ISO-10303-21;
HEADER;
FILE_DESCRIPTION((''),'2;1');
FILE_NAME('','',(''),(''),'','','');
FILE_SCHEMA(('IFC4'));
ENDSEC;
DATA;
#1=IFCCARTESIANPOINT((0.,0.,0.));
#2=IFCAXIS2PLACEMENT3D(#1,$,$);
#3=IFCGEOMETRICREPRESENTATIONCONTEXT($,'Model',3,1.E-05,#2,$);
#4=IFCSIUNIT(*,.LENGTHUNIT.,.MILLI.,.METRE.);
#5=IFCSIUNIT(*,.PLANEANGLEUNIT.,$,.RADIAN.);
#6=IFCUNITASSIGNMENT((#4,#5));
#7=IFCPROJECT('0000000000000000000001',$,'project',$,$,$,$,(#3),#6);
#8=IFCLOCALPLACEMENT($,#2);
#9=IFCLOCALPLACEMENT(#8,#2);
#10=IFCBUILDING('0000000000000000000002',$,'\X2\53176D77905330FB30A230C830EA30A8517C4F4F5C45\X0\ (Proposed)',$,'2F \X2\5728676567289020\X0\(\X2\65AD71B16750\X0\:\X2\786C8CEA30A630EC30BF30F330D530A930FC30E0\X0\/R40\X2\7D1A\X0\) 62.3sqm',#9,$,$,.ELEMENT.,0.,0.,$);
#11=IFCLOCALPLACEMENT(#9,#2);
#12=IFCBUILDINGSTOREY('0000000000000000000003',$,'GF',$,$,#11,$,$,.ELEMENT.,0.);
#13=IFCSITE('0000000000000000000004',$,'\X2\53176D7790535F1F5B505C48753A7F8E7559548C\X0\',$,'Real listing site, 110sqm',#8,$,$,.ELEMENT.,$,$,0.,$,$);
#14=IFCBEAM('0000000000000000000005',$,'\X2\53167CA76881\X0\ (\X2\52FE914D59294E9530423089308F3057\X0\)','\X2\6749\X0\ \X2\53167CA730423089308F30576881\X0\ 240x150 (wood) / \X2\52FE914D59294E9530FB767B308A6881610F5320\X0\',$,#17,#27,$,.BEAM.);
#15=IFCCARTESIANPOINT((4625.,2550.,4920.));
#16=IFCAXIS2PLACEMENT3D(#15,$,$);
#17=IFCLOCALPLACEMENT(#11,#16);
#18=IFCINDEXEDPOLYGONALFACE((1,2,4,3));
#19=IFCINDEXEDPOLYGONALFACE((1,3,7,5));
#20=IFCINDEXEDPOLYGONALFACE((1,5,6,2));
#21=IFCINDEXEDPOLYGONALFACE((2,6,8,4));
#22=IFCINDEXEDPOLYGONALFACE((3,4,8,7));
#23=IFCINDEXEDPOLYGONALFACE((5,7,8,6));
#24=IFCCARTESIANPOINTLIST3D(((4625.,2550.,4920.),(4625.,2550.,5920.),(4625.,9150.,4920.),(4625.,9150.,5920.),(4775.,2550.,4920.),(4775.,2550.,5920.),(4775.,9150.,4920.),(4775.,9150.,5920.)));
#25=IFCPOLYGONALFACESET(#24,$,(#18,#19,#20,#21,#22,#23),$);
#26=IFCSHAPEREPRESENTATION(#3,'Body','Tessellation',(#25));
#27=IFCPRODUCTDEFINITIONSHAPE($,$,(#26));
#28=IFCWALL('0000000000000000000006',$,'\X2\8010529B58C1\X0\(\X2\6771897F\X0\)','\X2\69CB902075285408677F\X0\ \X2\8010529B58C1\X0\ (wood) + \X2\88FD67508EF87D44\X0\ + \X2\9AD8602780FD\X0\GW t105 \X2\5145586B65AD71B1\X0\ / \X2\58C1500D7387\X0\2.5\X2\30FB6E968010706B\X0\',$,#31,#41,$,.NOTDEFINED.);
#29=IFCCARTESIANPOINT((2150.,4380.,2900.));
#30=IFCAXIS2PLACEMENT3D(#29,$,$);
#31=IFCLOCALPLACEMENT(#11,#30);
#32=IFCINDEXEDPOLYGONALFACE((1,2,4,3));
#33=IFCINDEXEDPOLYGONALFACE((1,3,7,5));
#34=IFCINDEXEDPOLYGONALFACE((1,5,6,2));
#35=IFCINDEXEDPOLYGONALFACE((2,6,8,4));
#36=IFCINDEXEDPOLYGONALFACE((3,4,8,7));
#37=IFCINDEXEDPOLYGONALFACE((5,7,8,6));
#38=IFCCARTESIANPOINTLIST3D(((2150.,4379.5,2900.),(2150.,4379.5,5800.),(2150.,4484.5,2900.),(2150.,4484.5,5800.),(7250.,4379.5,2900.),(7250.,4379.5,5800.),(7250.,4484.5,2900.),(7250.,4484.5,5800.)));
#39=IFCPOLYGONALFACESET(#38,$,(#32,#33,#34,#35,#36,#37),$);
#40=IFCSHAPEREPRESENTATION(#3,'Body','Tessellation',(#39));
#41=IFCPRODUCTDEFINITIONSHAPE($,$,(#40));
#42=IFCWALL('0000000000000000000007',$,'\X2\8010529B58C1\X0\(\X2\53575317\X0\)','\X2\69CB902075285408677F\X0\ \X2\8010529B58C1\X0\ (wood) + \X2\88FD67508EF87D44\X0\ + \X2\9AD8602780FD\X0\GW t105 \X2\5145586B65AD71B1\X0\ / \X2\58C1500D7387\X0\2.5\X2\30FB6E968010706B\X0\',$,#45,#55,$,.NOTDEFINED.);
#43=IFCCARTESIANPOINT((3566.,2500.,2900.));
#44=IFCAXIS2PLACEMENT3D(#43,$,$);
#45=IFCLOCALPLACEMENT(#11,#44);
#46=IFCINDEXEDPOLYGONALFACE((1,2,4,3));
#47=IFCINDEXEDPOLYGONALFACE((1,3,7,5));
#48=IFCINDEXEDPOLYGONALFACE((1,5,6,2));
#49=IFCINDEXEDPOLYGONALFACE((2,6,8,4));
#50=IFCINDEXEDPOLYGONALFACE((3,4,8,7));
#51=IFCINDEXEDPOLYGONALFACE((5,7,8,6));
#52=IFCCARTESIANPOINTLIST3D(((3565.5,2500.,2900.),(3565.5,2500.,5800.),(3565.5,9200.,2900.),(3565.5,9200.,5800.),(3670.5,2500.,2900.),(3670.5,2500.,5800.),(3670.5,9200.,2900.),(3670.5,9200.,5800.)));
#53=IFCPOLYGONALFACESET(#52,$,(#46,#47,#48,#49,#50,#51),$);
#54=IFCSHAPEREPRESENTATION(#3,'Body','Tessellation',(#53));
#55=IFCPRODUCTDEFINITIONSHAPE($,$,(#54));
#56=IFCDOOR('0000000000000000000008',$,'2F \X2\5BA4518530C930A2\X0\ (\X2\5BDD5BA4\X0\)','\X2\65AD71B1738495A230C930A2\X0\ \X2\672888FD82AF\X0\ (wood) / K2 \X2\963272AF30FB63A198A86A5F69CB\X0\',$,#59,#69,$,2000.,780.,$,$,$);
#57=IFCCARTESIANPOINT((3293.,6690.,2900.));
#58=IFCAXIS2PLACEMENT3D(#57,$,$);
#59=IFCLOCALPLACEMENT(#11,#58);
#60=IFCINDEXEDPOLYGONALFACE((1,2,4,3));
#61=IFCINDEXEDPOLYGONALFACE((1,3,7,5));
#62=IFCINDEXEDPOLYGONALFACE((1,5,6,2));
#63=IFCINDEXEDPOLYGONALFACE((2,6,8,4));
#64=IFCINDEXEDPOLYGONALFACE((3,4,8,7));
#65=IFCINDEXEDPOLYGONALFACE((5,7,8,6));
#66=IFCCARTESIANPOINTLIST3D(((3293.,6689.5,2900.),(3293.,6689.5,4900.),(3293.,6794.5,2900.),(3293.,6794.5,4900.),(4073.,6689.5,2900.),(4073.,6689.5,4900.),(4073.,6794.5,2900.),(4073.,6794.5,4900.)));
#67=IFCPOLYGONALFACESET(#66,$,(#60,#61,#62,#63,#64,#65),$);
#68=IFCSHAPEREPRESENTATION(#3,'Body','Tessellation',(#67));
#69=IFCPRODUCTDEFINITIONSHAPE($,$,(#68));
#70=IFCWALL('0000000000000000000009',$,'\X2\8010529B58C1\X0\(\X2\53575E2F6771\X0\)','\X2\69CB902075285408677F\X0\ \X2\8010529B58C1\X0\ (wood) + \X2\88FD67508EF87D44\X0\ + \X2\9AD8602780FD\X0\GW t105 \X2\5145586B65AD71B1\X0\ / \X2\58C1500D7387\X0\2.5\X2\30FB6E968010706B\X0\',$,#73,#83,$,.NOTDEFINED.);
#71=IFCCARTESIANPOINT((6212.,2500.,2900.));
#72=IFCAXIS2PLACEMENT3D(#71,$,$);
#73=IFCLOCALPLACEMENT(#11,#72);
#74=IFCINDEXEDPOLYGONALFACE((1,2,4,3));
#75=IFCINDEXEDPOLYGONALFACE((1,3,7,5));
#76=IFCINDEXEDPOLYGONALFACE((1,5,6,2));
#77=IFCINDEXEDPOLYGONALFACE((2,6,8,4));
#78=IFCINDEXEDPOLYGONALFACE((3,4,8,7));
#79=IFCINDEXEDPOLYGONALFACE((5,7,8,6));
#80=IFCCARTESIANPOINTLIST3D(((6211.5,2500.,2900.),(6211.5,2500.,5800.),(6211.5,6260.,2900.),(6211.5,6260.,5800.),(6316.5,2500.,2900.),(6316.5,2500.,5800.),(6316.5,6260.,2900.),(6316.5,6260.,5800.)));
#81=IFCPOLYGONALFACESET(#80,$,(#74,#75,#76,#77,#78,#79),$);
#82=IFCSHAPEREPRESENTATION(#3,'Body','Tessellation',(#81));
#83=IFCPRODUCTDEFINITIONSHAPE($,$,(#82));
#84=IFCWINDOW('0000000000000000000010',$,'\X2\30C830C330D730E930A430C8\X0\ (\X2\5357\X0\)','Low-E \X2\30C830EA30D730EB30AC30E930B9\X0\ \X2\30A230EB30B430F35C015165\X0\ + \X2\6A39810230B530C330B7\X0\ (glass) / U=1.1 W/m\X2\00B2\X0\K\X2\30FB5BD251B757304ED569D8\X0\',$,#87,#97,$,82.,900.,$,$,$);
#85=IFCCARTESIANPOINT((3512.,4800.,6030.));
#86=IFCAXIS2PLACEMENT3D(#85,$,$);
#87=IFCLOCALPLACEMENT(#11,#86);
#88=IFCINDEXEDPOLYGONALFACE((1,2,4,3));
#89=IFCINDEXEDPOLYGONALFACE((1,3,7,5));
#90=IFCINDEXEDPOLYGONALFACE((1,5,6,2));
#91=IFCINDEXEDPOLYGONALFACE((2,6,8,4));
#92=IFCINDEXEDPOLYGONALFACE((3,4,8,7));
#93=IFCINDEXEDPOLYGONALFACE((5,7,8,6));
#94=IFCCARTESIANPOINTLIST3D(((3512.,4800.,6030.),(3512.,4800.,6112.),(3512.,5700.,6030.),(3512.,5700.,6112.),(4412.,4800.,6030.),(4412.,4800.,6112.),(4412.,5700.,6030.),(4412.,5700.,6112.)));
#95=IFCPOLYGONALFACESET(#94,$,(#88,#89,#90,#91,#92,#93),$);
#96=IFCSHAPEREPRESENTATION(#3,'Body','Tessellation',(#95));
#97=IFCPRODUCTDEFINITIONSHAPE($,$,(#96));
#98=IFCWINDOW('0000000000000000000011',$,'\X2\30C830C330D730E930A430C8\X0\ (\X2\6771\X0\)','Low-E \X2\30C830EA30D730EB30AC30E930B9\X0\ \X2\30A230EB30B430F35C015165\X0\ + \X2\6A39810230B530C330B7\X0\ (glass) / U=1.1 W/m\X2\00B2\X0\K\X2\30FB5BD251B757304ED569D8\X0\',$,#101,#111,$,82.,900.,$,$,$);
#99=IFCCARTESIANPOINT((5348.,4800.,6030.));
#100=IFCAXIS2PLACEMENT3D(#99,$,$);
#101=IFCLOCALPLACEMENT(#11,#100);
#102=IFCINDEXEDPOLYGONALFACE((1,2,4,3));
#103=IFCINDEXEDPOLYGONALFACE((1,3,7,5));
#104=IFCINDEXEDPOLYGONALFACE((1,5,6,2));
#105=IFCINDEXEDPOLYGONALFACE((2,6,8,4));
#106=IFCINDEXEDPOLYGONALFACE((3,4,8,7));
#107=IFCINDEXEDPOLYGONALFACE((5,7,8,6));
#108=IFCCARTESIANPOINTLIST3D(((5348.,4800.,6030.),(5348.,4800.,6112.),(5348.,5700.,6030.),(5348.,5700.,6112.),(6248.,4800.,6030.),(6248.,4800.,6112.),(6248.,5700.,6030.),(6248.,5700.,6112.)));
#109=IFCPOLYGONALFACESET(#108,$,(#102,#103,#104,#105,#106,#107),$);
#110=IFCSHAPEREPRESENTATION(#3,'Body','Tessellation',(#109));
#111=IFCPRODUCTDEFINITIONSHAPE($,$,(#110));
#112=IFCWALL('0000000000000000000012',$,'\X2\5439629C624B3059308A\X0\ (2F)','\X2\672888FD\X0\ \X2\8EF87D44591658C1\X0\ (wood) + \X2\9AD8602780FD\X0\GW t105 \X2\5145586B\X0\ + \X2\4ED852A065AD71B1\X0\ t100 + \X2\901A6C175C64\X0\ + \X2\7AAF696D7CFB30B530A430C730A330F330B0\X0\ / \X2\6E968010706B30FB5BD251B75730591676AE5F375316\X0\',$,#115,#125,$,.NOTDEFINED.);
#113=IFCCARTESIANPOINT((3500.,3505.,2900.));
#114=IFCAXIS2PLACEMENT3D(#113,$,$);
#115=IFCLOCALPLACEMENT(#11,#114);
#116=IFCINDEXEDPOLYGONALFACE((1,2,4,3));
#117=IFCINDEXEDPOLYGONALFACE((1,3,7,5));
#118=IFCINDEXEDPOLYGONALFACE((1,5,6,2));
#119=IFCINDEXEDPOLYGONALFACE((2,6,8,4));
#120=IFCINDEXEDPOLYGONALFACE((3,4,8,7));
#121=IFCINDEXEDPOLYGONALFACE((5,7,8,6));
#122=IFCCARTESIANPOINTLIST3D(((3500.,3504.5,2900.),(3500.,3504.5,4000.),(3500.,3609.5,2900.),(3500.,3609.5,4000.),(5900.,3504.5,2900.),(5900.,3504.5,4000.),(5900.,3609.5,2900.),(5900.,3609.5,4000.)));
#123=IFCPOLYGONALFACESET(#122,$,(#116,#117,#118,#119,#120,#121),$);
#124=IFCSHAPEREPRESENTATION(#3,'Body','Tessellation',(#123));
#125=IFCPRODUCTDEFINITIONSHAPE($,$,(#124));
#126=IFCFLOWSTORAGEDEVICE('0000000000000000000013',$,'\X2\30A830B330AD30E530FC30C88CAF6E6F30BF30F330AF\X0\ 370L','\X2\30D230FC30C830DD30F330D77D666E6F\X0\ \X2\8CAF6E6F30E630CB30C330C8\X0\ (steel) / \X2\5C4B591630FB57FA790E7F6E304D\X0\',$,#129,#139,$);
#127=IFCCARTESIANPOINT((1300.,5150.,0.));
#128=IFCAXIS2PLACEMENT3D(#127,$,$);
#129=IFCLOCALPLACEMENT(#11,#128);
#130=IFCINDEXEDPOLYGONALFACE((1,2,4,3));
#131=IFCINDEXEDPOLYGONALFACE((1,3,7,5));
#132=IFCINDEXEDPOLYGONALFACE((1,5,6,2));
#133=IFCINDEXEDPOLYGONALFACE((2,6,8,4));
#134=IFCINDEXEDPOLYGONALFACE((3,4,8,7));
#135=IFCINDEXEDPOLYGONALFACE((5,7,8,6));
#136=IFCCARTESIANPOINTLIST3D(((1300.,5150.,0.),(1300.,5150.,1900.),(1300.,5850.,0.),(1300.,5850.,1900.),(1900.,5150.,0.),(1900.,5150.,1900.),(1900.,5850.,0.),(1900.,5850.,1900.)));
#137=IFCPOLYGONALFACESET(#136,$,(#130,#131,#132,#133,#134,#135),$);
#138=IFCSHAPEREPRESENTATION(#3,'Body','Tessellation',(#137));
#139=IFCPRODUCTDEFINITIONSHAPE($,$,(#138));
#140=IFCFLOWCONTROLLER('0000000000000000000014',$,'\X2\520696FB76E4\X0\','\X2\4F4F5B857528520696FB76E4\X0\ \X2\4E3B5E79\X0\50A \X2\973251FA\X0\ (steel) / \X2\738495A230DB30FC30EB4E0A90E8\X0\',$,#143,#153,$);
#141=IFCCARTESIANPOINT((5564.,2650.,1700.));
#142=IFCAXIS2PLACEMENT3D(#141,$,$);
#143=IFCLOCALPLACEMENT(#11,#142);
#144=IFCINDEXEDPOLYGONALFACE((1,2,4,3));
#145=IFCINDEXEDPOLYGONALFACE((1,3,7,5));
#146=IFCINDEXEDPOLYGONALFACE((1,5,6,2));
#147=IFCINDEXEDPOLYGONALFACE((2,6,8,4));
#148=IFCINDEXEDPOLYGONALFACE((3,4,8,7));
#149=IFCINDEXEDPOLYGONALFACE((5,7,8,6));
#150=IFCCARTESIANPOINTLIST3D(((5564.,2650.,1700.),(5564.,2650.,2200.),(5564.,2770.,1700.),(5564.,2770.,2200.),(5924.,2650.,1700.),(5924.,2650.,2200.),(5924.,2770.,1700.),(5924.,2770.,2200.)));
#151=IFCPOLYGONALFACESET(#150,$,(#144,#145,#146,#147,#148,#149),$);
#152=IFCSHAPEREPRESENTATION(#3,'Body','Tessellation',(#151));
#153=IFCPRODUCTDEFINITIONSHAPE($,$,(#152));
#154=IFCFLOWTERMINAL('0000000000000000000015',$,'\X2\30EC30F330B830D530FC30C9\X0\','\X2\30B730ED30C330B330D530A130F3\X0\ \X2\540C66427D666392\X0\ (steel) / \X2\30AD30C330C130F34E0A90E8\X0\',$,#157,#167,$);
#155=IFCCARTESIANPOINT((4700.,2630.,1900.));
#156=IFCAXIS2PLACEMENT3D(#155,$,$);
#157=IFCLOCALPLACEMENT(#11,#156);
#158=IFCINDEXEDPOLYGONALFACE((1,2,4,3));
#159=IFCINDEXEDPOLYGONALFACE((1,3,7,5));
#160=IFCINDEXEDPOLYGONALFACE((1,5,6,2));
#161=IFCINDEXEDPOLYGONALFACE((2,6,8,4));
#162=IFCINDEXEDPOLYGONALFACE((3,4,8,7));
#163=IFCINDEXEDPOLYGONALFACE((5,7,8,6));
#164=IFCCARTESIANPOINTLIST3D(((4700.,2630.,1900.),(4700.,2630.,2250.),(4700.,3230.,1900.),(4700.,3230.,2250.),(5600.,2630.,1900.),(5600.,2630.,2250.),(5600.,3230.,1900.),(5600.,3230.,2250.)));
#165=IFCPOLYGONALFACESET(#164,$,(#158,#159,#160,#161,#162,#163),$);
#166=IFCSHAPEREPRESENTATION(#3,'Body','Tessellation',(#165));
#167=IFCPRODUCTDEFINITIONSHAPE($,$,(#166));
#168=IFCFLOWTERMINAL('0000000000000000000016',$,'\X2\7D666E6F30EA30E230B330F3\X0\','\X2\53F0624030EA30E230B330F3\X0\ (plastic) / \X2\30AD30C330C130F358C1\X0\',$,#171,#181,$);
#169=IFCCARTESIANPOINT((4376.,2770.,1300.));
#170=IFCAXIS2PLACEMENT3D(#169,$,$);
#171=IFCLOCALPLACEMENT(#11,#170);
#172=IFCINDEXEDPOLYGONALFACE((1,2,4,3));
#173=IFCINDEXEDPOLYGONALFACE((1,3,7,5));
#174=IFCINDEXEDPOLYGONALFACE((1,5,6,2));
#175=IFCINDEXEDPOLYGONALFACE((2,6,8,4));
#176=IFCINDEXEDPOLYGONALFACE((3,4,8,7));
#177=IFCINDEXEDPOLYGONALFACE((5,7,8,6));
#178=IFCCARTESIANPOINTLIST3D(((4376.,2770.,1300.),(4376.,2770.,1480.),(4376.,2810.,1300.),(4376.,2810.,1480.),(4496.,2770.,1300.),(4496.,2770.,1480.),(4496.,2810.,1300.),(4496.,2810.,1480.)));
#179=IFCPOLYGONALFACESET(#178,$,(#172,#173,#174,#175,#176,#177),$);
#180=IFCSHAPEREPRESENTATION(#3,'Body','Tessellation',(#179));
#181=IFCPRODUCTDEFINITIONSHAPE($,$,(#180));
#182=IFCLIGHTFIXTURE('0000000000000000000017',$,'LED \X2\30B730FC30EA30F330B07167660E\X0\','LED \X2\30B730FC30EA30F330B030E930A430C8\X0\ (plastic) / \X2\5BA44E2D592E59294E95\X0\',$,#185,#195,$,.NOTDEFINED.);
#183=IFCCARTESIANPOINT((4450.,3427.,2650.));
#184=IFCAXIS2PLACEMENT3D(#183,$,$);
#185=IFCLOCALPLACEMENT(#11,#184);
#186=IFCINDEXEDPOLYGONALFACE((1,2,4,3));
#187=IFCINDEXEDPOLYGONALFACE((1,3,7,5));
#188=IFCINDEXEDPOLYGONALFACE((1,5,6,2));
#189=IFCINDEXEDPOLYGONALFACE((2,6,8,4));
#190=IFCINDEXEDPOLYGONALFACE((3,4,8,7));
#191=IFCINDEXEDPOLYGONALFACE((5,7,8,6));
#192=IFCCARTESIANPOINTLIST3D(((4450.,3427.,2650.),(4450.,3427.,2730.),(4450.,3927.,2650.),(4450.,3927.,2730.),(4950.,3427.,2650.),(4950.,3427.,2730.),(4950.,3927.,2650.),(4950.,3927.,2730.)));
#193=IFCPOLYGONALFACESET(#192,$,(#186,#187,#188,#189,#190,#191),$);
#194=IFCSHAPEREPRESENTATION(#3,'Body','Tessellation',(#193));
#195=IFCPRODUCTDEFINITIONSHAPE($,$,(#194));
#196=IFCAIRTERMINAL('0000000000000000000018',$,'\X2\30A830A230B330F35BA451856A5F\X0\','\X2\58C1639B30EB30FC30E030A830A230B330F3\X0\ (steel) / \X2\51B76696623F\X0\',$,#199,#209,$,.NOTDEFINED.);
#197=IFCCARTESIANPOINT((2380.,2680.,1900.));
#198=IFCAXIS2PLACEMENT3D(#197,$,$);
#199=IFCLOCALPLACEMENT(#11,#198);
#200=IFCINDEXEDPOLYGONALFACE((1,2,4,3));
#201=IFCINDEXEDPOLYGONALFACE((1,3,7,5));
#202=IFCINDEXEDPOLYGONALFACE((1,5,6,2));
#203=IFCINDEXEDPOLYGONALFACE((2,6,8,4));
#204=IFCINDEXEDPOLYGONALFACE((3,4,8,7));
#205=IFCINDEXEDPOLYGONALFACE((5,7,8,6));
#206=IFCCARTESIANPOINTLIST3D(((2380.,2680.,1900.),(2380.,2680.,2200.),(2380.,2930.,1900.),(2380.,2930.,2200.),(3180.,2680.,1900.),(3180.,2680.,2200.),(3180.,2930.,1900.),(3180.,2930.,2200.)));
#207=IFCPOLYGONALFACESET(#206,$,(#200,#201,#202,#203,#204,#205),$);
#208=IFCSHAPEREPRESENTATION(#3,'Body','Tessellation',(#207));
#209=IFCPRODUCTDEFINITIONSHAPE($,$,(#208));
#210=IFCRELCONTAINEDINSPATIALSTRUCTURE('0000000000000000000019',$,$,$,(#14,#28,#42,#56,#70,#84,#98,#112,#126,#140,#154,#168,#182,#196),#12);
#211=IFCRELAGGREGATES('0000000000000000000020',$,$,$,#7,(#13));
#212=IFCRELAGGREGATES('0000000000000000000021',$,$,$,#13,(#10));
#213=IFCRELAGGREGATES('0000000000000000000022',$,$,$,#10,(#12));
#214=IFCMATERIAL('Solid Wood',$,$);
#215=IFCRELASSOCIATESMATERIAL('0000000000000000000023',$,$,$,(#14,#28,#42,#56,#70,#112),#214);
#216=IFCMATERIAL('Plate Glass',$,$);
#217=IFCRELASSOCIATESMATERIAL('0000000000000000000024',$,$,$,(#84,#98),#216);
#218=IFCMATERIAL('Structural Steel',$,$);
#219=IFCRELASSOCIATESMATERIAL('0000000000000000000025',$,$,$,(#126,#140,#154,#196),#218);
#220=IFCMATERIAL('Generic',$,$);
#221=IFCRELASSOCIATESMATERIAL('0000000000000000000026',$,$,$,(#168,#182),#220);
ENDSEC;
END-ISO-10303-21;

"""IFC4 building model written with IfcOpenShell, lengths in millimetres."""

from ifc_helpers import new_model, si_unit, frame, frame_2d, origin, place, context, project, spatial, rectangle, extrude, material, element, fill, save


model = new_model("IFC4")

# Units and contexts
model_context = context("Model", 3, precision=1e-05, world=origin())
ifc_project = project(units=[si_unit("LENGTHUNIT", "METRE", prefix="MILLI"), si_unit("PLANEANGLEUNIT", "RADIAN")], contexts=[model_context])

# Site, building, storey
site_placement = place(None, origin())
site = spatial("IfcSite", under=ifc_project, at=site_placement, Name="北海道弟子屈町美留和", ObjectType="Real listing site, 110sqm", CompositionType="ELEMENT", RefElevation=0.0)
building_placement = place(site_placement, origin())
building = spatial("IfcBuilding", under=site, at=building_placement, Name="北海道・アトリエ兼住居 (Proposed)", ObjectType="2F 在来木造(断熱材:硬質ウレタンフォーム/R40級) 62.3sqm", CompositionType="ELEMENT", ElevationOfRefHeight=0.0, ElevationOfTerrain=0.0)
storey_placement = place(building_placement, origin())
storey = spatial("IfcBuildingStorey", under=building, at=storey_placement, Name="GF", CompositionType="ELEMENT", Elevation=0.0)

# Shared definitions
ifc_material_1 = material(Name="Solid Wood")

# Beam
beam_placement = place(storey_placement, frame((4625.0, 2550.0, 4920.0)))
element("IfcBeam", 1, at=beam_placement, inside=storey, material=ifc_material_1, Name="化粧梁 (勾配天井あらわし)", Description="杉 化粧あらわし梁 240x150 (wood) / 勾配天井・登り梁意匠", PredefinedType="BEAM", context=model_context, shape_type="SweptSolid", body=[
    extrude(rectangle(XDim=150.0, YDim=6600.0, at=frame_2d((75.0, 3300.0))), frame((4625.0, 2550.0, 4920.0)), (0.0, 0.0, 1.0), 1000.0),
])

# Wall
wall_1_placement = place(storey_placement, frame((2150.0, 4380.0, 2900.0)))
element("IfcWall", 2, at=wall_1_placement, inside=storey, material=ifc_material_1, Name="耐力壁(東西)", Description="構造用合板 耐力壁 (wood) + 製材軸組 + 高性能GW t105 充填断熱 / 壁倍率2.5・準耐火", PredefinedType="NOTDEFINED", context=model_context, shape_type="SweptSolid", body=[
    extrude(rectangle(XDim=5100.0, YDim=105.0, at=frame_2d((2550.0, 52.0))), frame((2150.0, 4380.0, 2900.0)), (0.0, 0.0, 1.0), 2900.0),
])

# Wall, opening, door
wall_2_placement = place(storey_placement, frame((3566.0, 2500.0, 2900.0)))
wall_2 = element("IfcWall", 3, at=wall_2_placement, inside=storey, material=ifc_material_1, Name="耐力壁(南北)", Description="構造用合板 耐力壁 (wood) + 製材軸組 + 高性能GW t105 充填断熱 / 壁倍率2.5・準耐火", PredefinedType="NOTDEFINED", context=model_context, shape_type="SweptSolid", body=[
    extrude(rectangle(XDim=105.0, YDim=6700.0, at=frame_2d((52.0, 3350.0))), frame((3566.0, 2500.0, 2900.0)), (0.0, 0.0, 1.0), 2900.0),
])
opening_placement = place(storey_placement, frame((3293.0, 6690.0, 2900.0)))
opening = element("IfcOpeningElement", 4, at=opening_placement, cuts=wall_2, PredefinedType="NOTDEFINED", context=model_context, shape_type="SweptSolid", body=[
    extrude(rectangle(XDim=780.0, YDim=105.0, at=frame_2d((390.0, 52.0))), frame((3293.0, 6690.0, 2900.0)), (0.0, 0.0, 1.0), 2000.0),
])
door_placement = place(storey_placement, frame((3293.0, 6690.0, 2900.0)))
door = element("IfcDoor", 5, at=door_placement, inside=storey, material=ifc_material_1, Name="2F 室内ドア (寝室)", Description="断熱玄関ドア 木製芯 (wood) / K2 防犯・採風機構", OverallHeight=2000.0, OverallWidth=780.0, context=model_context, shape_type="SweptSolid", body=[
    extrude(rectangle(XDim=780.0, YDim=105.0, at=frame_2d((390.0, 52.0))), frame((3293.0, 6690.0, 2900.0)), (0.0, 0.0, 1.0), 2000.0),
])
fill(opening, door)

# Wall
wall_3_placement = place(storey_placement, frame((6212.0, 2500.0, 2900.0)))
element("IfcWall", 6, at=wall_3_placement, inside=storey, material=ifc_material_1, Name="耐力壁(南帯東)", Description="構造用合板 耐力壁 (wood) + 製材軸組 + 高性能GW t105 充填断熱 / 壁倍率2.5・準耐火", PredefinedType="NOTDEFINED", context=model_context, shape_type="SweptSolid", body=[
    extrude(rectangle(XDim=105.0, YDim=3760.0, at=frame_2d((52.0, 1880.0))), frame((6212.0, 2500.0, 2900.0)), (0.0, 0.0, 1.0), 2900.0),
])

# Windows
ifc_material_2 = material(Name="Plate Glass")
window_1_placement = place(storey_placement, frame((3512.0, 4800.0, 6030.0)))
element("IfcWindow", 7, at=window_1_placement, inside=storey, material=ifc_material_2, Name="トップライト (南)", Description="Low-E トリプルガラス アルゴン封入 + 樹脂サッシ (glass) / U=1.1 W/m²K・寒冷地仕様", OverallHeight=82.0, OverallWidth=900.0, context=model_context, shape_type="SweptSolid", body=[
    extrude(rectangle(XDim=900.0, YDim=900.0, at=frame_2d((450.0, 450.0))), frame((3512.0, 4800.0, 6030.0)), (0.0, 0.0, 1.0), 82.0),
])
window_2_placement = place(storey_placement, frame((5348.0, 4800.0, 6030.0)))
element("IfcWindow", 8, at=window_2_placement, inside=storey, material=ifc_material_2, Name="トップライト (東)", Description="Low-E トリプルガラス アルゴン封入 + 樹脂サッシ (glass) / U=1.1 W/m²K・寒冷地仕様", OverallHeight=82.0, OverallWidth=900.0, context=model_context, shape_type="SweptSolid", body=[
    extrude(rectangle(XDim=900.0, YDim=900.0, at=frame_2d((450.0, 450.0))), frame((5348.0, 4800.0, 6030.0)), (0.0, 0.0, 1.0), 82.0),
])

# Wall
wall_4_placement = place(storey_placement, frame((3500.0, 3505.0, 2900.0)))
element("IfcWall", 9, at=wall_4_placement, inside=storey, material=ifc_material_1, Name="吹抜手すり (2F)", Description="木製 軸組外壁 (wood) + 高性能GW t105 充填 + 付加断熱 t100 + 通気層 + 窯業系サイディング / 準耐火・寒冷地外皮強化", PredefinedType="NOTDEFINED", context=model_context, shape_type="SweptSolid", body=[
    extrude(rectangle(XDim=2400.0, YDim=105.0, at=frame_2d((1200.0, 52.0))), frame((3500.0, 3505.0, 2900.0)), (0.0, 0.0, 1.0), 1100.0),
])

# Flow storage device
ifc_material_3 = material(Name="Structural Steel")
flow_storage_device_placement = place(storey_placement, frame((1300.0, 5150.0, 0.0)))
element("IfcFlowStorageDevice", 10, at=flow_storage_device_placement, inside=storey, material=ifc_material_3, Name="エコキュート貯湯タンク 370L", Description="ヒートポンプ給湯 貯湯ユニット (steel) / 屋外・基礎置き", context=model_context, shape_type="SweptSolid", body=[
    extrude(rectangle(XDim=600.0, YDim=700.0, at=frame_2d((300.0, 350.0))), frame((1300.0, 5150.0, 0.0)), (0.0, 0.0, 1.0), 1900.0),
])

# Flow controller
flow_controller_placement = place(storey_placement, frame((5564.0, 2650.0, 1700.0)))
element("IfcFlowController", 11, at=flow_controller_placement, inside=storey, material=ifc_material_3, Name="分電盤", Description="住宅用分電盤 主幹50A 露出 (steel) / 玄関ホール上部", context=model_context, shape_type="SweptSolid", body=[
    extrude(rectangle(XDim=360.0, YDim=120.0, at=frame_2d((180.0, 60.0))), frame((5564.0, 2650.0, 1700.0)), (0.0, 0.0, 1.0), 500.0),
])

# Flow terminals
flow_terminal_1_placement = place(storey_placement, frame((4700.0, 2630.0, 1900.0)))
element("IfcFlowTerminal", 12, at=flow_terminal_1_placement, inside=storey, material=ifc_material_3, Name="レンジフード", Description="シロッコファン 同時給排 (steel) / キッチン上部", context=model_context, shape_type="SweptSolid", body=[
    extrude(rectangle(XDim=900.0, YDim=600.0, at=frame_2d((450.0, 300.0))), frame((4700.0, 2630.0, 1900.0)), (0.0, 0.0, 1.0), 350.0),
])
ifc_material_4 = material(Name="Generic")
flow_terminal_2_placement = place(storey_placement, frame((4376.0, 2770.0, 1300.0)))
element("IfcFlowTerminal", 13, at=flow_terminal_2_placement, inside=storey, material=ifc_material_4, Name="給湯リモコン", Description="台所リモコン (plastic) / キッチン壁", context=model_context, shape_type="SweptSolid", body=[
    extrude(rectangle(XDim=120.0, YDim=40.0, at=frame_2d((60.0, 20.0))), frame((4376.0, 2770.0, 1300.0)), (0.0, 0.0, 1.0), 180.0),
])

# Light fixture
light_fixture_1_placement = place(storey_placement, frame((4450.0, 3427.0, 2650.0)))
element("IfcLightFixture", 14, at=light_fixture_1_placement, inside=storey, material=ifc_material_4, Name="LED シーリング照明", Description="LED シーリングライト (plastic) / 室中央天井", PredefinedType="NOTDEFINED", context=model_context, shape_type="SweptSolid", body=[
    extrude(rectangle(XDim=500.0, YDim=500.0, at=frame_2d((250.0, 250.0))), frame((4450.0, 3427.0, 2650.0)), (0.0, 0.0, 1.0), 80.0),
])

# Air terminal
air_terminal_1_placement = place(storey_placement, frame((2380.0, 2680.0, 1900.0)))
element("IfcAirTerminal", 15, at=air_terminal_1_placement, inside=storey, material=ifc_material_3, Name="エアコン室内機", Description="壁掛ルームエアコン (steel) / 冷暖房", PredefinedType="NOTDEFINED", context=model_context, shape_type="SweptSolid", body=[
    extrude(rectangle(XDim=800.0, YDim=250.0, at=frame_2d((400.0, 125.0))), frame((2380.0, 2680.0, 1900.0)), (0.0, 0.0, 1.0), 300.0),
])

save(model, "model.ifc")
